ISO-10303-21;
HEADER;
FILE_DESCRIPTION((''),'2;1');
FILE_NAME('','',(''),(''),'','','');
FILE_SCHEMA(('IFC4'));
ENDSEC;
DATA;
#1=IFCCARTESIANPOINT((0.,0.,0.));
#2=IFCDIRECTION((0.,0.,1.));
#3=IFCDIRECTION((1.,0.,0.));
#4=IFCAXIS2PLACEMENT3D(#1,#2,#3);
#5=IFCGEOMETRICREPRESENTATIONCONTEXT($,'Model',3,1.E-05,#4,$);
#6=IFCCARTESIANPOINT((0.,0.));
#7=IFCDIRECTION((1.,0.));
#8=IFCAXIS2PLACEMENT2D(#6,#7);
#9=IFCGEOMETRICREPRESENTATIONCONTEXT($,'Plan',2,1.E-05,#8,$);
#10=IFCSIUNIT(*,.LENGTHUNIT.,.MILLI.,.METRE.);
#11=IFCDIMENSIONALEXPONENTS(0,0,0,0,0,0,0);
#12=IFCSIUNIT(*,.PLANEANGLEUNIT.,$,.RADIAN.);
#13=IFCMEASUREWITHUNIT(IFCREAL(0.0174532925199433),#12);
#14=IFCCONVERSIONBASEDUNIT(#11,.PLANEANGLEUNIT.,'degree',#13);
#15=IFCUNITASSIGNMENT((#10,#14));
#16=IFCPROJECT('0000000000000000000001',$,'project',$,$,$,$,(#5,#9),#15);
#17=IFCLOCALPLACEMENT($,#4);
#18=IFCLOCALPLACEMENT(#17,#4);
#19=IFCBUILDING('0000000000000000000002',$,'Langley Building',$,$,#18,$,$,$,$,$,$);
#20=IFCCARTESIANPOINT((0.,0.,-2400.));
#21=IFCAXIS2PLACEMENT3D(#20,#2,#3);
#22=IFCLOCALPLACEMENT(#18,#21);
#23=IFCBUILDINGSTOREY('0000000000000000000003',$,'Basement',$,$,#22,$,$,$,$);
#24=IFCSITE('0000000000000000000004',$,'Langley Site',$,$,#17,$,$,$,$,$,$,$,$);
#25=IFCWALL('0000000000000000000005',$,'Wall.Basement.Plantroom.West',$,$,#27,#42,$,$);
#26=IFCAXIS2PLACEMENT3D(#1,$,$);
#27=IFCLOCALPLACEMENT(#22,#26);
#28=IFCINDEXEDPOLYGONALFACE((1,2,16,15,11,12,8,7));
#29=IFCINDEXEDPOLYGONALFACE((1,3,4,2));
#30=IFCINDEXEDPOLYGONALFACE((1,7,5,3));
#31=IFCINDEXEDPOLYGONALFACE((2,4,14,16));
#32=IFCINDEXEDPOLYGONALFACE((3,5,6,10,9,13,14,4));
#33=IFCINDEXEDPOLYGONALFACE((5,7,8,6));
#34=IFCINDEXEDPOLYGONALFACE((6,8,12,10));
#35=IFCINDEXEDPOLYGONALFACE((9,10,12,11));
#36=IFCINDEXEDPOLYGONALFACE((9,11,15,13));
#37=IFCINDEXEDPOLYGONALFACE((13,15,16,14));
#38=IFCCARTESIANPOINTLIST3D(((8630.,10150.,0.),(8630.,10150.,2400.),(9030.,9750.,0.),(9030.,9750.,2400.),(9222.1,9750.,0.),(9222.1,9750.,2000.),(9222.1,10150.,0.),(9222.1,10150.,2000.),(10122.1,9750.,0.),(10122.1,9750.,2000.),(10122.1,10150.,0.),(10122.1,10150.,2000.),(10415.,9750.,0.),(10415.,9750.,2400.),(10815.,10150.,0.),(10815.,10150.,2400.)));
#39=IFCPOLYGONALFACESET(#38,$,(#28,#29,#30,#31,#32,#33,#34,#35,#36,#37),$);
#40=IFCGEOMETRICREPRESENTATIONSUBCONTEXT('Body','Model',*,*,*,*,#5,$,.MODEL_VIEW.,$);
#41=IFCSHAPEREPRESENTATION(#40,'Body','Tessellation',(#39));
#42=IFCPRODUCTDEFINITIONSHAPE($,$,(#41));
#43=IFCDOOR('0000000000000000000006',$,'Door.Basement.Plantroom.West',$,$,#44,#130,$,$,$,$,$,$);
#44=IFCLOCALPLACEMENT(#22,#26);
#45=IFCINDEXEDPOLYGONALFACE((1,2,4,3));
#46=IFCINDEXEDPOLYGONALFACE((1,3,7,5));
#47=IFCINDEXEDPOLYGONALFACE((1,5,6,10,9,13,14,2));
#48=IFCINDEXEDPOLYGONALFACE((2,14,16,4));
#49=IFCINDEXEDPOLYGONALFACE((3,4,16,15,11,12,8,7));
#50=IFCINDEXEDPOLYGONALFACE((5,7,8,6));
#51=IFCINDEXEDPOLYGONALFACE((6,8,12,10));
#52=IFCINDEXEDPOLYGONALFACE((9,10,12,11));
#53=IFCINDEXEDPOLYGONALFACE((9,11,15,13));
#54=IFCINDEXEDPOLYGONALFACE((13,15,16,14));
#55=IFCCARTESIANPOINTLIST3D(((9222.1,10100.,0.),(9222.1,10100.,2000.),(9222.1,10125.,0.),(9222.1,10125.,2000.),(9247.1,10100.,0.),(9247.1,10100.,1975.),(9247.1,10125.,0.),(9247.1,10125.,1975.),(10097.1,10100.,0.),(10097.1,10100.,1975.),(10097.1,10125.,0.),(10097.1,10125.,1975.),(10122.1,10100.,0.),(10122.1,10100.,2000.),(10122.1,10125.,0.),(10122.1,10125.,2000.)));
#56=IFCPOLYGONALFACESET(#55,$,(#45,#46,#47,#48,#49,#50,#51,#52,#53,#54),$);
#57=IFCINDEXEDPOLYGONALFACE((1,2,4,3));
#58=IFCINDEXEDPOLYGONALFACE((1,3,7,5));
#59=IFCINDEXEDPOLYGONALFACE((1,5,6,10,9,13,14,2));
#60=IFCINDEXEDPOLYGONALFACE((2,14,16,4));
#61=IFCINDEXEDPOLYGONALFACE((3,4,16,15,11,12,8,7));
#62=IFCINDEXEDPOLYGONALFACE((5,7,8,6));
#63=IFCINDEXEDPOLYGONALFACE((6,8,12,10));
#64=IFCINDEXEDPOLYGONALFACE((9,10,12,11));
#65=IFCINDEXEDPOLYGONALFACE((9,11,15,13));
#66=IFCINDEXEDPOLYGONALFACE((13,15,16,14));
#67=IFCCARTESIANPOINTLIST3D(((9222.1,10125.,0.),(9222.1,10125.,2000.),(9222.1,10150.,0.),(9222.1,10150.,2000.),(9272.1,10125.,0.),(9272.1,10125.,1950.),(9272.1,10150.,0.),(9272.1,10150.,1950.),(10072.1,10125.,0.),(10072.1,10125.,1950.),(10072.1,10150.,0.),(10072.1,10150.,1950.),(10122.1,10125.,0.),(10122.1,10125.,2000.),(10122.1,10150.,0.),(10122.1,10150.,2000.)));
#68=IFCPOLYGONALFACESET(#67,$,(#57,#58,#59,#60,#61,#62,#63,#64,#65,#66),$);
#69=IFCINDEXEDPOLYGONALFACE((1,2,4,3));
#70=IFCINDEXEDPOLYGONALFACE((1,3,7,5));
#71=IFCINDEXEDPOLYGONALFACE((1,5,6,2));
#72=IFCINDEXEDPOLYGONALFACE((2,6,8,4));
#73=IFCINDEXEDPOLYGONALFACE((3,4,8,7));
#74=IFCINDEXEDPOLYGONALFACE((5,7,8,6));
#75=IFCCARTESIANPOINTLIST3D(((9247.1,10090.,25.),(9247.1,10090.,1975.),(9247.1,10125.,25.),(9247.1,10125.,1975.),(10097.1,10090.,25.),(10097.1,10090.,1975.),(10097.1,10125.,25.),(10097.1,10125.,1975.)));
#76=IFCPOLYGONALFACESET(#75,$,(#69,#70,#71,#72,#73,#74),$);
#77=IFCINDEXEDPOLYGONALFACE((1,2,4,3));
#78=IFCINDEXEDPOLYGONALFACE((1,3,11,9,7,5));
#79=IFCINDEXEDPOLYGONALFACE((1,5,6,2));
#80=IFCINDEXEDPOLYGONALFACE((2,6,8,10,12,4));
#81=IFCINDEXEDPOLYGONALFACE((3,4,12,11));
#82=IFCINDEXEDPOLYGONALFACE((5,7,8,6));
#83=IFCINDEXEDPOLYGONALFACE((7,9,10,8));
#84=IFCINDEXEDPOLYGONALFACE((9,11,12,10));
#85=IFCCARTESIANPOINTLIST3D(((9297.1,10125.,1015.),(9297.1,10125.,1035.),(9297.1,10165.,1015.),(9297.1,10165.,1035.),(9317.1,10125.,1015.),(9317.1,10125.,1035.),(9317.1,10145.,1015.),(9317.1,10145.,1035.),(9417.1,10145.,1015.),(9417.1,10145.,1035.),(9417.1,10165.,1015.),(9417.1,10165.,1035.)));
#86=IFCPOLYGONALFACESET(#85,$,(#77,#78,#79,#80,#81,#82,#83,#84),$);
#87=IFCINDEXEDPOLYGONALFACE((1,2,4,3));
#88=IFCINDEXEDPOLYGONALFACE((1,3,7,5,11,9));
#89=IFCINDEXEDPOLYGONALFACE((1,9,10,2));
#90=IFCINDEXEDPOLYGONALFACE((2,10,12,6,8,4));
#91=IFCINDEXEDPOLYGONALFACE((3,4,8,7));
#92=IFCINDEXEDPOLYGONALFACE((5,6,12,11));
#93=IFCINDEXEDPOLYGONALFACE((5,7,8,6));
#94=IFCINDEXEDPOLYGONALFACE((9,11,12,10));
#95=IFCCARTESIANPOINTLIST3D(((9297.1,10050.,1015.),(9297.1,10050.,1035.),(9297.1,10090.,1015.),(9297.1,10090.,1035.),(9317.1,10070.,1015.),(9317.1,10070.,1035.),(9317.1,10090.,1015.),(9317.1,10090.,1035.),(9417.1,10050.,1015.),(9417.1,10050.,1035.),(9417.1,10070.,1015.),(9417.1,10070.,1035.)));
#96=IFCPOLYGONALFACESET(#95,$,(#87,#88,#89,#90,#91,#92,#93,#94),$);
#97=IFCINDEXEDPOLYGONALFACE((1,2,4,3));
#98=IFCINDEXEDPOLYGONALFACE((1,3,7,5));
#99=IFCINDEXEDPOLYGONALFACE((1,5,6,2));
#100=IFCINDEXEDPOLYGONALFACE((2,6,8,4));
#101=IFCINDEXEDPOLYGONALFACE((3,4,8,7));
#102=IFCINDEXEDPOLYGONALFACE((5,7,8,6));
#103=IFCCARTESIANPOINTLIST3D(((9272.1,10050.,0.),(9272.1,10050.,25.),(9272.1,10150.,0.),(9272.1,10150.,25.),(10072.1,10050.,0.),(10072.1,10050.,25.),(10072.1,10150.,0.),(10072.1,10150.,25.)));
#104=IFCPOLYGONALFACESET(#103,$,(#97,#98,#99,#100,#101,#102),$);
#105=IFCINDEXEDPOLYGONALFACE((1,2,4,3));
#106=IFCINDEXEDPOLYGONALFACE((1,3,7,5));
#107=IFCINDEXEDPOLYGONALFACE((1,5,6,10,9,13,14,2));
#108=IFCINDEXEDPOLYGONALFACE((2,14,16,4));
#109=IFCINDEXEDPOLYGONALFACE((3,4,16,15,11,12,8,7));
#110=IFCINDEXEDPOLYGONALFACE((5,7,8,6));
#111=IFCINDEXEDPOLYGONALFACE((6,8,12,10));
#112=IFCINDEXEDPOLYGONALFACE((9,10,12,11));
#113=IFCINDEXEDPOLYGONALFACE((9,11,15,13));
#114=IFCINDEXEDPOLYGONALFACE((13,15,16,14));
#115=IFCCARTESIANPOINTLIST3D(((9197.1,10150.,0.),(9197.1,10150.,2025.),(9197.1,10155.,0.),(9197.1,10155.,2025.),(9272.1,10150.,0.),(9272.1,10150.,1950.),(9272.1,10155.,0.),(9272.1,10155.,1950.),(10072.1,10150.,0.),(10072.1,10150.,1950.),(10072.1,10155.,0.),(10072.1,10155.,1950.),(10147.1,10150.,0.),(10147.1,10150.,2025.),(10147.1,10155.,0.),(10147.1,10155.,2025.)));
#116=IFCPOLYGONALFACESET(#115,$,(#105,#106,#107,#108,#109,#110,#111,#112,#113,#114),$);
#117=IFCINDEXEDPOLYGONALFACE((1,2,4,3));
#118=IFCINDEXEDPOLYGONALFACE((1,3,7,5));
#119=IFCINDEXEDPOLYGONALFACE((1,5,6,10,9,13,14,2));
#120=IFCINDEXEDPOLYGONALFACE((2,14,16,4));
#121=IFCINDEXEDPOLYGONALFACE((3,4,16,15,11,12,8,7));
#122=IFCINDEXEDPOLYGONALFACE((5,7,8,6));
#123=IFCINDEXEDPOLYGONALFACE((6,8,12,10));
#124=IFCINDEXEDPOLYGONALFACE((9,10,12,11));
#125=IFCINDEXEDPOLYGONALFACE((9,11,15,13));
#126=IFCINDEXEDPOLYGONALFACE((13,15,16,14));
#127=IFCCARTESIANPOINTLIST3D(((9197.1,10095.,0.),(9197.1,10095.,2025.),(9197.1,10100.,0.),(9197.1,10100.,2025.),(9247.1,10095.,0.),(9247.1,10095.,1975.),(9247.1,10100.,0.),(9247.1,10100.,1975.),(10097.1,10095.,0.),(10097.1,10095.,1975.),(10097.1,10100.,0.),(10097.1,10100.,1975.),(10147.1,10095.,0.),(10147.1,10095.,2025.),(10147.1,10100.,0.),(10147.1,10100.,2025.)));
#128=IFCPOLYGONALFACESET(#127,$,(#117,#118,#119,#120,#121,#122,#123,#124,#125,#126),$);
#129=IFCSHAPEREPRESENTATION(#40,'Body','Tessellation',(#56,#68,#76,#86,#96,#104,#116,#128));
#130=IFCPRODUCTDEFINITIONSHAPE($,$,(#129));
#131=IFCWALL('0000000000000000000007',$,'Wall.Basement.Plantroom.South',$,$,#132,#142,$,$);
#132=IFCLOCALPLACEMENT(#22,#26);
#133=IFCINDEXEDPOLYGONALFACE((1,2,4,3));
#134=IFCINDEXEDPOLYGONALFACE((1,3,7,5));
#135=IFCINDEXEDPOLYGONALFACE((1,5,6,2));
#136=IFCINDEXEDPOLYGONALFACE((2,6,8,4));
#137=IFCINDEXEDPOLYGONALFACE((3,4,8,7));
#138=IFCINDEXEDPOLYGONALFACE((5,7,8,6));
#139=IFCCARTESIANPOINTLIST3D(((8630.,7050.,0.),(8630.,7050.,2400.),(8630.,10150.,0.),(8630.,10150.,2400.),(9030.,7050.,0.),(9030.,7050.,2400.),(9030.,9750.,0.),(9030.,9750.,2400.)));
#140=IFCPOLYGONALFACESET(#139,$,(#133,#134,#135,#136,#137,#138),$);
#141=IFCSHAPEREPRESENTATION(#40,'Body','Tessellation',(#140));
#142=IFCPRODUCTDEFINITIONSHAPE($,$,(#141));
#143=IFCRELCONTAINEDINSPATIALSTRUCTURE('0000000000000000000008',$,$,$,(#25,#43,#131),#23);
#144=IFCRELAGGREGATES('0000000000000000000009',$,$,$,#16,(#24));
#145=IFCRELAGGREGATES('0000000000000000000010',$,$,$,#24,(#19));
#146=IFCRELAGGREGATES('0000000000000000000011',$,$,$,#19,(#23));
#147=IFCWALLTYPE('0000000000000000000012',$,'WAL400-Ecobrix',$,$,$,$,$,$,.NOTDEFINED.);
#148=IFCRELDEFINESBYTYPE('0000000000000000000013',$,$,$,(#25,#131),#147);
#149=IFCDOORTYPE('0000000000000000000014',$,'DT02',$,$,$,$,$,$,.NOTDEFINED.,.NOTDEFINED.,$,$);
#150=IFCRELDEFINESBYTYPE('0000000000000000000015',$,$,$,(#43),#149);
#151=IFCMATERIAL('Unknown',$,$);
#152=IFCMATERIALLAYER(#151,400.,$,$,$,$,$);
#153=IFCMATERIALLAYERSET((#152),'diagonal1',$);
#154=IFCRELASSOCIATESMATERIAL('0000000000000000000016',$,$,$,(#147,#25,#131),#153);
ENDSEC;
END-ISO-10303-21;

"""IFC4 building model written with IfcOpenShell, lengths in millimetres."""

from ifc_helpers import new_model, entity, si_unit, converted_unit, frame, origin_with_axes, origin_2d_with_axis, place, context, subcontext, project, spatial, line, indexed_curve, outline, extrude, shape, source, transform, mapped, material, layer, layer_set, layer_usage, type_object, type_shapes, element, fill, save


model = new_model("IFC4")

# Units and contexts
model_context = context("Model", 3, precision=1e-05, world=origin_with_axes())
plan_context = context("Plan", 2, precision=1e-05, world=origin_2d_with_axis())
body_context_1 = subcontext(model_context, "Body", "Model", "MODEL_VIEW")
body_context_2 = subcontext(plan_context, "Body", "Plan", "PLAN_VIEW")
ifc_project = project(units=[si_unit("LENGTHUNIT", "METRE", prefix="MILLI"), converted_unit("PLANEANGLEUNIT", "degree", entity("IfcReal", 0.0174532925199433), si_unit("PLANEANGLEUNIT", "RADIAN"), dimensions=[0, 0, 0, 0, 0, 0, 0])], contexts=[model_context, plan_context])

# Site, building, storey
site_placement = place(None, origin_with_axes())
site = spatial("IfcSite", under=ifc_project, at=site_placement, Name="Langley Site")
building_placement = place(site_placement, origin_with_axes())
building = spatial("IfcBuilding", under=site, at=building_placement, Name="Langley Building")
storey_placement = place(building_placement, frame((0.0, 0.0, -2400.0), z_axis=(0.0, 0.0, 1.0), x_axis=(1.0, 0.0, 0.0)))
storey = spatial("IfcBuildingStorey", under=building, at=storey_placement, Name="Basement")

# Shared definitions
ifc_material = material(Name="Unknown")
ifc_layer_1 = layer(ifc_material, 400.0)
ifc_layer_set_1 = layer_set([ifc_layer_1], Name="diagonal1")
wall_type_1 = type_object("IfcWallType", Name="WAL400-Ecobrix", PredefinedType="NOTDEFINED", material=ifc_layer_set_1)

# Wall, opening, door
ifc_layer_usage_1 = layer_usage(ifc_layer_set_1, "AXIS2", "POSITIVE", 0.0)
wall_1_placement = place(storey_placement, frame((10815.0, 10150.0, 0.0), z_axis=(0.0, 0.0, 1.0), x_axis=(-1.0, 0.0, 0.0)))
wall_1 = element("IfcWall", 1, at=wall_1_placement, inside=storey, type_object=wall_type_1, material=ifc_layer_usage_1, Name="Wall.Basement.Plantroom.West", context=body_context_1, shape_type="SweptSolid", body=[
    extrude(outline(indexed_curve([(0.0, 0.0), (400.0, 400.0), (1785.0, 400.0), (2185.0, 0.0)], segments=[line(1, 2, 3, 4, 1)])), origin_with_axes(), (0.0, 0.0, 1.0), 2400.0),
])
shared_shape_1 = source(origin_with_axes(), body_context_1, "Body", "SweptSolid", [
    extrude(outline(indexed_curve([(0.0, 0.0), (900.0, 0.0), (900.0, 2000.0), (0.0, 2000.0)], segments=[line(1, 2, 3, 4, 1)])), frame((0.0, -600.0, 0.0), z_axis=(0.0, -1.0, 0.0), x_axis=(1.0, 0.0, 0.0)), (0.0, 0.0, -1.0), 1200.0),
])
opening_placement = place(wall_1_placement, frame((692.9, 0.0, 0.0), z_axis=(0.0, 0.0, 1.0), x_axis=(1.0, 0.0, 0.0)))
opening = element("IfcOpeningElement", 2, at=opening_placement, cuts=wall_1, PredefinedType="OPENING", context=body_context_1, shape_type="MappedRepresentation", body=[
    mapped(shared_shape_1, transform((0.0, 0.0, 0.0), x_axis=(1.0, 0.0, 0.0), y_axis=(0.0, 1.0, 0.0), z_axis=(0.0, 0.0, 1.0), scale=1.0)),
])
door_type = type_object("IfcDoorType", Name="DT02", OperationType="NOTDEFINED", PredefinedType="NOTDEFINED")
shared_shape_2 = source(origin_with_axes(), body_context_1, "Body", "SweptSolid", [
    extrude(outline(indexed_curve([(0.0, 0.0), (0.0, 2000.0), (900.0, 2000.0), (900.0, 0.0), (875.0, 0.0), (875.0, 1975.0), (25.0, 1975.0), (25.0, 0.0)], segments=[line(1, 2, 3, 4, 5, 6, 7, 8, 1)])), frame((0.0, 25.0, 0.0), z_axis=(0.0, -1.0, 0.0), x_axis=(1.0, 0.0, 0.0)), (0.0, 0.0, -1.0), 25.0),
    extrude(outline(indexed_curve([(0.0, 0.0), (0.0, 2000.0), (900.0, 2000.0), (900.0, 0.0), (850.0, 0.0), (850.0, 1950.0), (50.0, 1950.0), (50.0, 0.0)], segments=[line(1, 2, 3, 4, 5, 6, 7, 8, 1)])), frame((0.0, 0.0, 0.0), z_axis=(0.0, -1.0, 0.0), x_axis=(1.0, 0.0, 0.0)), (0.0, 0.0, -1.0), 25.0),
    extrude(outline(indexed_curve([(0.0, 0.0), (850.0, 0.0), (850.0, 35.0), (0.0, 35.0)], segments=[line(1, 2, 3, 4, 1)])), frame((25.0, 25.0, 25.0), z_axis=(0.0, 0.0, 1.0), x_axis=(1.0, 0.0, 0.0)), (0.0, 0.0, 1.0), 1950.0),
    extrude(outline(indexed_curve([(0.0, 0.0), (0.0, -40.0), (-120.0, -40.0), (-120.0, -20.0), (-20.0, -20.0), (-20.0, 0.0)], segments=[line(1, 2, 3, 4, 5, 6, 1)])), frame((825.0, 25.0, 1015.0), z_axis=(0.0, 0.0, 1.0), x_axis=(1.0, 0.0, 0.0)), (0.0, 0.0, 1.0), 20.0),
    extrude(outline(indexed_curve([(0.0, 0.0), (0.0, 40.0), (-120.0, 40.0), (-120.0, 20.0), (-20.0, 20.0), (-20.0, 0.0)], segments=[line(1, 2, 3, 4, 5, 6, 1)])), frame((825.0, 60.0, 1015.0), z_axis=(0.0, 0.0, 1.0), x_axis=(1.0, 0.0, 0.0)), (0.0, 0.0, 1.0), 20.0),
    extrude(outline(indexed_curve([(0.0, 0.0), (800.0, 0.0), (800.0, 100.0), (0.0, 100.0)], segments=[line(1, 2, 3, 4, 1)])), frame((50.0, 0.0, 0.0), z_axis=(0.0, 0.0, 1.0), x_axis=(1.0, 0.0, 0.0)), (0.0, 0.0, 1.0), 25.0),
    extrude(outline(indexed_curve([(0.0, 0.0), (0.0, 2025.0), (950.0, 2025.0), (950.0, 0.0), (875.0, 0.0), (875.0, 1950.0), (75.0, 1950.0), (75.0, 0.0)], segments=[line(1, 2, 3, 4, 5, 6, 7, 8, 1)])), frame((-25.0, -5.0, 0.0), z_axis=(0.0, -1.0, 0.0), x_axis=(1.0, 0.0, 0.0)), (0.0, 0.0, -1.0), 5.0),
    extrude(outline(indexed_curve([(0.0, 0.0), (0.0, 2025.0), (950.0, 2025.0), (950.0, 0.0), (900.0, 0.0), (900.0, 1975.0), (50.0, 1975.0), (50.0, 0.0)], segments=[line(1, 2, 3, 4, 5, 6, 7, 8, 1)])), frame((-25.0, 50.0, 0.0), z_axis=(0.0, -1.0, 0.0), x_axis=(1.0, 0.0, 0.0)), (0.0, 0.0, -1.0), 5.0),
])
shared_shape_3 = source(origin_with_axes(), body_context_2, "Body", "Curve2D", [
    entity("IfcIndexedPolyCurve", entity("IfcCartesianPointList2D", [[0.0, 0.0], [0.0, 50.0], [25.0, 50.0], [25.0, 25.0], [50.0, 25.0], [50.0, 0.0]]), [entity("IfcLineIndex", [1, 2, 3, 4, 5, 6, 1])]),
    entity("IfcIndexedPolyCurve", entity("IfcCartesianPointList2D", [[900.0, 0.0], [900.0, 50.0], [875.0, 50.0], [875.0, 25.0], [850.0, 25.0], [850.0, 0.0]]), [entity("IfcLineIndex", [1, 2, 3, 4, 5, 6, 1])]),
    entity("IfcTrimmedCurve", entity("IfcEllipse", entity("IfcAxis2Placement2D", entity("IfcCartesianPoint", [60.0, 50.0]), entity("IfcDirection", [1.0, 0.0])), 815.0, 850.0), [entity("IfcCartesianPoint", [875.0, 50.0])], [entity("IfcCartesianPoint", [60.0, 900.0])], True, "CARTESIAN"),
    entity("IfcIndexedPolyCurve", entity("IfcCartesianPointList2D", [[25.0, 50.0], [60.0, 50.0], [60.0, 900.0], [25.0, 900.0]]), [entity("IfcLineIndex", [1, 2, 3, 4, 1])]),
])
type_shapes(door_type, [shared_shape_2, shared_shape_3])
door_placement = place(opening_placement, frame((0.0, 0.0, 0.0), z_axis=(0.0, 0.0, 1.0), x_axis=(1.0, 0.0, 0.0)))
door = element("IfcDoor", 3, at=door_placement, inside=storey, type_object=door_type, Name="Door.Basement.Plantroom.West", shapes=[
    shape(body_context_1, "Body", "MappedRepresentation", [mapped(shared_shape_2, transform((0.0, 0.0, 0.0), x_axis=(1.0, 0.0, 0.0), y_axis=(0.0, 1.0, 0.0), z_axis=(0.0, 0.0, 1.0), scale=1.0))]),
    shape(body_context_2, "Body", "MappedRepresentation", [mapped(shared_shape_3, transform((0.0, 0.0, 0.0), x_axis=(1.0, 0.0, 0.0), y_axis=(0.0, 1.0, 0.0), z_axis=(0.0, 0.0, 1.0), scale=1.0))]),
])
fill(opening, door)

# Wall
ifc_layer_usage_2 = layer_usage(ifc_layer_set_1, "AXIS2", "POSITIVE", 0.0)
wall_2_placement = place(storey_placement, frame((8630.0, 10150.0, 0.0), z_axis=(0.0, 0.0, 1.0), x_axis=(0.0, -1.0, 0.0)))
element("IfcWall", 4, at=wall_2_placement, inside=storey, type_object=wall_type_1, material=ifc_layer_usage_2, Name="Wall.Basement.Plantroom.South", context=body_context_1, shape_type="SweptSolid", body=[
    extrude(outline(indexed_curve([(0.0, 0.0), (400.0, 400.0), (3100.0, 400.0), (3100.0, 0.0)], segments=[line(1, 2, 3, 4, 1)])), origin_with_axes(), (0.0, 0.0, 1.0), 2400.0),
])

save(model, "model.ifc")
